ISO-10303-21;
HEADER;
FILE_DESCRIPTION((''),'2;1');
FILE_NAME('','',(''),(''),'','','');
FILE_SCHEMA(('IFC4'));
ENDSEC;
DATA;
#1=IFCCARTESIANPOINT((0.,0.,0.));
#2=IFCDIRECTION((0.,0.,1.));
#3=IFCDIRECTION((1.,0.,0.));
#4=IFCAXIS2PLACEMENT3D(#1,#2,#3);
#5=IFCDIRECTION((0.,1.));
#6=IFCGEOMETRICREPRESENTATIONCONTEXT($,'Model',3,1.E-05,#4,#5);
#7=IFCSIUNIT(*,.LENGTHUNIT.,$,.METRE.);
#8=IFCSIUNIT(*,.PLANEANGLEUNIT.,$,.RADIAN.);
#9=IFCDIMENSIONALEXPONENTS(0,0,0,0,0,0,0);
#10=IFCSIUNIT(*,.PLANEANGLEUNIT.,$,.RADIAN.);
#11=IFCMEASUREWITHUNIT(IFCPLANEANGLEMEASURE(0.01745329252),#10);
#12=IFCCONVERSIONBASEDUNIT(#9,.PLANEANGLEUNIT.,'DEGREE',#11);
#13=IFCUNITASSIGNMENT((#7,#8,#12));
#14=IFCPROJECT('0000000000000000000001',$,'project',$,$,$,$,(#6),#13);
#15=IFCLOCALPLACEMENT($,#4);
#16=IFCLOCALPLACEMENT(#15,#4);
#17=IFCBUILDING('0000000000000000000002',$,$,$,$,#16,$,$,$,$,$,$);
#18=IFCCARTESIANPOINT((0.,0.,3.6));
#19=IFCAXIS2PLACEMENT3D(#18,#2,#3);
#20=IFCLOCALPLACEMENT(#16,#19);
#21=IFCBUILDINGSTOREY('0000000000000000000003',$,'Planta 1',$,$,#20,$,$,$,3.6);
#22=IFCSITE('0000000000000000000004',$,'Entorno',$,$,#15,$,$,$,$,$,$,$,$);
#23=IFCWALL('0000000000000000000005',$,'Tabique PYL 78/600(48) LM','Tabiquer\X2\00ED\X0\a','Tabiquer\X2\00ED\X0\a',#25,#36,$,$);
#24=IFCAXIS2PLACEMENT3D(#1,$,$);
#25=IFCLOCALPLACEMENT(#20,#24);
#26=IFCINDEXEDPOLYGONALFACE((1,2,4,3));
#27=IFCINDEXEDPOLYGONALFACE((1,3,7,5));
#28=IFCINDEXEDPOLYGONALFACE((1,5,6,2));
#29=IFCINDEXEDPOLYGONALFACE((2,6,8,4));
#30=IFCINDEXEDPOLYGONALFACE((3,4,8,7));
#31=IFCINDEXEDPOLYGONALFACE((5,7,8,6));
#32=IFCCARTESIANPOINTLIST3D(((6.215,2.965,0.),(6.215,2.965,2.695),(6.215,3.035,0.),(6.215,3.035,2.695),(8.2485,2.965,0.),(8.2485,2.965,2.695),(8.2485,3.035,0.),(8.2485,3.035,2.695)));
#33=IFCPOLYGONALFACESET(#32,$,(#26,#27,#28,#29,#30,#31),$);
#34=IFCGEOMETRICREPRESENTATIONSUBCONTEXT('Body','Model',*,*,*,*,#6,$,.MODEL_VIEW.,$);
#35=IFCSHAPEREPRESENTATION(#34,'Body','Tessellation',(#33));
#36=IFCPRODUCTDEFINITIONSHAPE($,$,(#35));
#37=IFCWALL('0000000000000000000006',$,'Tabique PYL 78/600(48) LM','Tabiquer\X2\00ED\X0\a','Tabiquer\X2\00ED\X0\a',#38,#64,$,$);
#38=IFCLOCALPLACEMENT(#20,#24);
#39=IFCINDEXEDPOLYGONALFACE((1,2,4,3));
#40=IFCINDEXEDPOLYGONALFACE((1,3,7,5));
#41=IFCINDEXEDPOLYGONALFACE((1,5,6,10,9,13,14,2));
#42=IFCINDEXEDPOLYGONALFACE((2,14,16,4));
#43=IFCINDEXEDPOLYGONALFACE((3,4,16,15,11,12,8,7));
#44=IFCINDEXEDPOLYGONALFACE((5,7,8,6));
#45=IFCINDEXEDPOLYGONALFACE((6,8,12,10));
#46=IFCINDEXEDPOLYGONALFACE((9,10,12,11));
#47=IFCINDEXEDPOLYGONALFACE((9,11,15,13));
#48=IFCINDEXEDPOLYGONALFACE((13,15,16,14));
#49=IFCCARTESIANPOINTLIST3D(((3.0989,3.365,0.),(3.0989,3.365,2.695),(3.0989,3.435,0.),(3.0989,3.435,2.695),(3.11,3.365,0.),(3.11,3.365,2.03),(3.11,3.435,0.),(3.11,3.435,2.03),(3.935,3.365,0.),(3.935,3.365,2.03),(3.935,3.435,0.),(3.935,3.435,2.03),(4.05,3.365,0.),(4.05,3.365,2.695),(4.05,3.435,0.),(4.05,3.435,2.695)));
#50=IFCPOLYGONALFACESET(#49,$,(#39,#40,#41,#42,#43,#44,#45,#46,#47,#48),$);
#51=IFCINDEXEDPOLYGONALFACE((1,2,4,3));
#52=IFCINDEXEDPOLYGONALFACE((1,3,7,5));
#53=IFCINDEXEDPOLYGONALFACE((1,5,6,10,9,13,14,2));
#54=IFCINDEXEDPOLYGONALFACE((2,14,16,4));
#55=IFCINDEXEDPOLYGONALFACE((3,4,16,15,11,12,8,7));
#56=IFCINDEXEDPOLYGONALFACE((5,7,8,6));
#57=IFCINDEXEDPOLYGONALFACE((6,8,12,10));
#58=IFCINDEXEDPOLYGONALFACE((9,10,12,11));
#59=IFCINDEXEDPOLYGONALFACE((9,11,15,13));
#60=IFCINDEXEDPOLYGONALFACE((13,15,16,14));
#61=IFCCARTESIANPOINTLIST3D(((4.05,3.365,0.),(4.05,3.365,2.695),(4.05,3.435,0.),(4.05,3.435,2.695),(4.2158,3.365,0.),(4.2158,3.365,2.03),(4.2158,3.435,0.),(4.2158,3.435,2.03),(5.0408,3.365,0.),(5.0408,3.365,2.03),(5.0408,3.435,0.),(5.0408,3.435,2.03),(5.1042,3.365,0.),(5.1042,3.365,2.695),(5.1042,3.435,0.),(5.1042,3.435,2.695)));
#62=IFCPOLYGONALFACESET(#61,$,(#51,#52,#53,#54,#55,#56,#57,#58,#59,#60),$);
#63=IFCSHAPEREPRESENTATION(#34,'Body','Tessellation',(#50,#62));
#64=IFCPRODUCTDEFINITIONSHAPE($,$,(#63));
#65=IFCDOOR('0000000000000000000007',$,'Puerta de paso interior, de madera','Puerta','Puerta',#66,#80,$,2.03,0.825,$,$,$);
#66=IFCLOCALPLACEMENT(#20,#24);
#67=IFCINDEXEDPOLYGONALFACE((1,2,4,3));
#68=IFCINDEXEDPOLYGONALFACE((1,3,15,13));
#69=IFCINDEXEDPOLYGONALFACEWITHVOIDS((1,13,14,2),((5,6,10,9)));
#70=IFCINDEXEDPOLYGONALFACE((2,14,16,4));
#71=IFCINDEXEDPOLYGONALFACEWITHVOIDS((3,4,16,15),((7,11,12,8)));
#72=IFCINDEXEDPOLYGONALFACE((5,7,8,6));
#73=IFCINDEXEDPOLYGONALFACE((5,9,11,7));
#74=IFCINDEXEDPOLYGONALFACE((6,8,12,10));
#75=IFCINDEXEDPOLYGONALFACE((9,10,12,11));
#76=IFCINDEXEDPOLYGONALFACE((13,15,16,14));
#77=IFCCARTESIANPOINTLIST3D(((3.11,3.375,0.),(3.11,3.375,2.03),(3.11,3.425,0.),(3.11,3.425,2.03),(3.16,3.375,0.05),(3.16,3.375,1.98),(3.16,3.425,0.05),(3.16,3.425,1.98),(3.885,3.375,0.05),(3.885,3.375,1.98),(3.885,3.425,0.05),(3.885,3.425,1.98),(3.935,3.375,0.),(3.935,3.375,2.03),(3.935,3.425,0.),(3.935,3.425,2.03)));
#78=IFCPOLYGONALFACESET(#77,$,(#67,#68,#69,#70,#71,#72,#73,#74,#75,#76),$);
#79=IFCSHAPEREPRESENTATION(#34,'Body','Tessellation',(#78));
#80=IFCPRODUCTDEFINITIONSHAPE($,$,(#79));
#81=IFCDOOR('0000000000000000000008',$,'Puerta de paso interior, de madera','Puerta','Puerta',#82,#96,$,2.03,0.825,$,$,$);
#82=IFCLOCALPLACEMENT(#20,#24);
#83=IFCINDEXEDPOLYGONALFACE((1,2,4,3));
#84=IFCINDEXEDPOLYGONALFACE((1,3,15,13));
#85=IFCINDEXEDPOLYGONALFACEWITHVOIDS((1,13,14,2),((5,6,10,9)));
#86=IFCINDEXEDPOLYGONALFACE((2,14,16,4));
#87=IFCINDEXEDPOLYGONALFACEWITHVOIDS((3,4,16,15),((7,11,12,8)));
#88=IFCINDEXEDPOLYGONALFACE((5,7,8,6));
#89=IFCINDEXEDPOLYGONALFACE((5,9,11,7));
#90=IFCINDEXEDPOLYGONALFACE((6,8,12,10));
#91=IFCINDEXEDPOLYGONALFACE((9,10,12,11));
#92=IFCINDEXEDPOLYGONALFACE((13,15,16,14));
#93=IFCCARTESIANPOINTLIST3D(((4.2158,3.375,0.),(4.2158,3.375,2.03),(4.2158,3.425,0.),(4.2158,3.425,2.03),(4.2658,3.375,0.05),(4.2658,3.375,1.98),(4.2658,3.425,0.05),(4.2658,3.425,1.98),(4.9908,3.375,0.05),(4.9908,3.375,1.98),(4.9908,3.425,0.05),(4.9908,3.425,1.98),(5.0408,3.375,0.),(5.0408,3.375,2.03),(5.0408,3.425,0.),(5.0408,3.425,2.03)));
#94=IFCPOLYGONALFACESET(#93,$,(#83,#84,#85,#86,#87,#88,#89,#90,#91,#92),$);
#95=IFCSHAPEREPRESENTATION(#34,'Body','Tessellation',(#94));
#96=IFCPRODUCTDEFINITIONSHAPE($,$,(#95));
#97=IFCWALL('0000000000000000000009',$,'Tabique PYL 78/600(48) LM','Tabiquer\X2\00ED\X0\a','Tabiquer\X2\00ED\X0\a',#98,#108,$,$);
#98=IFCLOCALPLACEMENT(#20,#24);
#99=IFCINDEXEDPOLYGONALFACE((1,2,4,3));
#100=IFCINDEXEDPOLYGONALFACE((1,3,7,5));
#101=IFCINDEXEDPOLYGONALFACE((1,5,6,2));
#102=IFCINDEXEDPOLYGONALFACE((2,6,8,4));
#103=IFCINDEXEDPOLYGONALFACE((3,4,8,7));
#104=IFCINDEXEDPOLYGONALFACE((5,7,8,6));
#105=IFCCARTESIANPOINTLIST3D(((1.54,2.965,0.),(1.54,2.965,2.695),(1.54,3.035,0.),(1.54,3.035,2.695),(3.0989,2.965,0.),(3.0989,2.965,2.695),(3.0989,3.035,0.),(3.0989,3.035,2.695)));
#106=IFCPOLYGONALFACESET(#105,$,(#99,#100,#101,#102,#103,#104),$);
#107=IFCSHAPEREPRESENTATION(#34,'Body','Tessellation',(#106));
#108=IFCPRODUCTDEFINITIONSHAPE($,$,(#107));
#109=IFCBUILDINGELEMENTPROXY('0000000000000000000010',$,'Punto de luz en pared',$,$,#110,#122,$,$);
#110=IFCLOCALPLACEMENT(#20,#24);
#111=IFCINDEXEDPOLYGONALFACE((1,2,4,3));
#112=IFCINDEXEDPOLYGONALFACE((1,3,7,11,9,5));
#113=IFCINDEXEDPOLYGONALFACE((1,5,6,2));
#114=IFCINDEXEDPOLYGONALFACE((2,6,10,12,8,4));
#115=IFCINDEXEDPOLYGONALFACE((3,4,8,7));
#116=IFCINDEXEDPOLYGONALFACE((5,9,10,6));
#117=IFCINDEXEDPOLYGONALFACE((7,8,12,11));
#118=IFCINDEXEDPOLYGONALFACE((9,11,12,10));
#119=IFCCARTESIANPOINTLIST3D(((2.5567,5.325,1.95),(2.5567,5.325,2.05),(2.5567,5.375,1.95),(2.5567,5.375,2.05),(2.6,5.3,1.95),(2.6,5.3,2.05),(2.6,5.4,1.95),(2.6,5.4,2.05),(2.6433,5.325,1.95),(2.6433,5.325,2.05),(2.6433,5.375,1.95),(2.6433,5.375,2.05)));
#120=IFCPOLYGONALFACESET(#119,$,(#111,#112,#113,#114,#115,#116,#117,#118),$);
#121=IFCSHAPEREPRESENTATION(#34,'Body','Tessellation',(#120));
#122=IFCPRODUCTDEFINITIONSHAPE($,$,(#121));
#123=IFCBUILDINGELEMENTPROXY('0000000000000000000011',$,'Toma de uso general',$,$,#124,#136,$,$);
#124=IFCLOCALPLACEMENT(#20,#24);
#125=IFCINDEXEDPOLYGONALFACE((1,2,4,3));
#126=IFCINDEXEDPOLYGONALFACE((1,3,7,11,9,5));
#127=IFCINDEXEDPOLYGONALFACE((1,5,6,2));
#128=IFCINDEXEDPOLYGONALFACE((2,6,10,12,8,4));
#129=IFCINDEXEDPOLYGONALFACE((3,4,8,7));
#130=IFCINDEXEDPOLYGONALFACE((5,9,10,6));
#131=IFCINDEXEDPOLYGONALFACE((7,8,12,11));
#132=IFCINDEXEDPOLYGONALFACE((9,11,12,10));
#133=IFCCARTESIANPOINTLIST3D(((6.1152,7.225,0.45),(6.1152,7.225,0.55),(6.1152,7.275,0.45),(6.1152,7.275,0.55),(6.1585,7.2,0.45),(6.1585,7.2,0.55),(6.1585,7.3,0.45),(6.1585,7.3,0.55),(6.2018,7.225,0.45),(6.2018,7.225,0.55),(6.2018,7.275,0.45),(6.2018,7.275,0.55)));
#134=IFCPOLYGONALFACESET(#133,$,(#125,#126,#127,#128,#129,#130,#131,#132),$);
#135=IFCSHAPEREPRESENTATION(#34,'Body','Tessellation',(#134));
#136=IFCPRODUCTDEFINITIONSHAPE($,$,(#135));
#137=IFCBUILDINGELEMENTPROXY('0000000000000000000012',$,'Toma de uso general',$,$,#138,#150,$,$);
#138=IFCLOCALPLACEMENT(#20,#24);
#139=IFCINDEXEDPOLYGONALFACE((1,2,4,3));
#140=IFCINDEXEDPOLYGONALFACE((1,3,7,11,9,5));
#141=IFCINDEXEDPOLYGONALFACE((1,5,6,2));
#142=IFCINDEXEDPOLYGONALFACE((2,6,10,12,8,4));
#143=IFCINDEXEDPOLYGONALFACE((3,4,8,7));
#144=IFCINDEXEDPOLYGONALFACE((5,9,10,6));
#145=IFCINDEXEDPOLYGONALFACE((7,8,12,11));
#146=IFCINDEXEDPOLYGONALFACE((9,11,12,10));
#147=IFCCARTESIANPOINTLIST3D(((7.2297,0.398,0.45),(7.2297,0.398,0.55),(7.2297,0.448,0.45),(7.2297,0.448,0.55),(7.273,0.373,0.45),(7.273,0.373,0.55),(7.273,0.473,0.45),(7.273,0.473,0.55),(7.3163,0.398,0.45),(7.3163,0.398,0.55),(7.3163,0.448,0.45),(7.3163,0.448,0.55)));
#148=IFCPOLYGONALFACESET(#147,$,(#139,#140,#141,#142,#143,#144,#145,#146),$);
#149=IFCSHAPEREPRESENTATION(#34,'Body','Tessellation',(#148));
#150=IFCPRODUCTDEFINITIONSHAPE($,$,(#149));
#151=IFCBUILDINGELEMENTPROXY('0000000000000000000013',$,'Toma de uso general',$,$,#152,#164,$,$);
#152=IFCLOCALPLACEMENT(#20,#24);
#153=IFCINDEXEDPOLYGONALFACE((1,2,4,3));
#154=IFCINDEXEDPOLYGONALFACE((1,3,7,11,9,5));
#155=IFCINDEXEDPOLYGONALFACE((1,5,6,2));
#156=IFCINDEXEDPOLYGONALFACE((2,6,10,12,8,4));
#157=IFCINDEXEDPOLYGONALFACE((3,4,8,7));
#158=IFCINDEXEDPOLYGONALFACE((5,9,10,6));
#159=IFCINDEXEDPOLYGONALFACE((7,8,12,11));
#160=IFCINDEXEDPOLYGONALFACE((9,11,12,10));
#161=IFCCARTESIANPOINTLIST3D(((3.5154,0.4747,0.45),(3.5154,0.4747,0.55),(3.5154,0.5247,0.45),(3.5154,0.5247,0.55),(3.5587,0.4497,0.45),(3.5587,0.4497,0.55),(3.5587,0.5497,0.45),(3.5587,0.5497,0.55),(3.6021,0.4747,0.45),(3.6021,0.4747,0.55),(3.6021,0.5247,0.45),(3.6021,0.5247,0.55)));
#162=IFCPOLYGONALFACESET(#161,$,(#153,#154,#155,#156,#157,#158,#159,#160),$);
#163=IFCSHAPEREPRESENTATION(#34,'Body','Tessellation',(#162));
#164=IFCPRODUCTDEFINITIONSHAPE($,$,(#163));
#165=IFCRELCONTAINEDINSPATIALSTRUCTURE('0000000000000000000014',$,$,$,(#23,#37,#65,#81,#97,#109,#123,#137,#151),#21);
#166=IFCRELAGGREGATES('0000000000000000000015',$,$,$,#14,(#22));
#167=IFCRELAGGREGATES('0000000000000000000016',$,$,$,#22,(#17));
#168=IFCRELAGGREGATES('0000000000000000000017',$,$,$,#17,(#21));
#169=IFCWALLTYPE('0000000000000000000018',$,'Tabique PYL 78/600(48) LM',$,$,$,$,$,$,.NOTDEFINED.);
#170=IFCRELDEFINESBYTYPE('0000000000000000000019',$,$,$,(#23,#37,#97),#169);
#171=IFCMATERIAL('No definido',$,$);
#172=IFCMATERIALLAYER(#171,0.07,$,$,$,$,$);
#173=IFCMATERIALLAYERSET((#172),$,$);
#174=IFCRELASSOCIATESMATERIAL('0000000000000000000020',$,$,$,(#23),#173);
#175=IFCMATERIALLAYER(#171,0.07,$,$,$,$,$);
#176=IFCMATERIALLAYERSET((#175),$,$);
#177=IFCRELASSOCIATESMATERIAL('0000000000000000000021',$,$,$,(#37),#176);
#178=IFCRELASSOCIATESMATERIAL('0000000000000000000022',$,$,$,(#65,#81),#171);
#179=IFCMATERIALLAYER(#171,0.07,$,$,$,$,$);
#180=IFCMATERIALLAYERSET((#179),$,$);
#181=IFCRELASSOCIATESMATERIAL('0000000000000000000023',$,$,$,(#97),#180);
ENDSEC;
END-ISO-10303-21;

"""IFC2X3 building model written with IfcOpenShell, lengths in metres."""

from ifc_helpers import new_model, entity, si_unit, converted_unit, direction, frame, origin_with_axes, origin_2d_with_axis, place, context, subcontext, project, spatial, polyline, rectangle, hollow_rectangle, outline, extrude, shape, source, transform, mapped, material, layer, layer_set, layer_usage, type_object, element, fill, save


model = new_model("IFC2X3")

# Units and contexts
model_context = context("Model", 3, precision=1e-05, world=origin_with_axes(), true_north=direction((0.0, 1.0)))
body_context = subcontext(model_context, "Body", "Model", "MODEL_VIEW")
footprint_context = subcontext(model_context, "FootPrint", "Model", "MODEL_VIEW")
ifc_project = project(units=[si_unit("LENGTHUNIT", "METRE"), si_unit("PLANEANGLEUNIT", "RADIAN"), converted_unit("PLANEANGLEUNIT", "DEGREE", entity("IfcPlaneAngleMeasure", 0.01745329252), si_unit("PLANEANGLEUNIT", "RADIAN"), dimensions=[0, 0, 0, 0, 0, 0, 0])], contexts=[model_context])

# Site, building, storey
site_placement = place(None, origin_with_axes())
site = spatial("IfcSite", under=ifc_project, at=site_placement, Name="Entorno")
building_placement = place(site_placement, origin_with_axes())
building = spatial("IfcBuilding", under=site, at=building_placement)
storey_placement = place(building_placement, frame((0.0, 0.0, 3.6), z_axis=(0.0, 0.0, 1.0), x_axis=(1.0, 0.0, 0.0)))
storey = spatial("IfcBuildingStorey", under=building, at=storey_placement, Name="Planta 1", Elevation=3.6)

# Shared definitions
ifc_material = material(Name="No definido")

# Shared definitions
wall_type = type_object("IfcWallType", Name="Tabique PYL 78/600(48) LM")

# Wall
ifc_layer_1 = layer(ifc_material, 0.07)
ifc_layer_set_1 = layer_set([ifc_layer_1])
ifc_layer_usage_1 = layer_usage(ifc_layer_set_1, "AXIS2", "POSITIVE", -0.035)
wall_1_placement = place(storey_placement, frame((6.25, 3.0, 0.0), z_axis=(0.0, 0.0, 1.0), x_axis=(1.0, 0.0, 0.0)))
element("IfcWall", 1, at=wall_1_placement, inside=storey, type_object=wall_type, material=ifc_layer_usage_1, Name="Tabique PYL 78/600(48) LM", Description="Tabiquería", ObjectType="Tabiquería", context=body_context, shape_type="SolidModel", body=[
    extrude(outline(polyline([(-1.0168, -1.3475), (1.0168, -1.3475), (1.0168, 1.3475), (-1.0168, 1.3475), (-1.0168, -1.3475)])), frame((0.9818, 0.035, 1.3475), z_axis=(0.0, -1.0, 0.0), x_axis=(1.0, 0.0, 0.0)), (0.0, 0.0, 1.0), 0.07),
])

# Wall, openings, doors
ifc_layer_2 = layer(ifc_material, 0.07)
ifc_layer_set_2 = layer_set([ifc_layer_2])
ifc_layer_usage_2 = layer_usage(ifc_layer_set_2, "AXIS2", "POSITIVE", -0.035)
wall_2_placement = place(storey_placement, frame((3.0639, 3.4, 0.0), z_axis=(0.0, 0.0, 1.0), x_axis=(1.0, 0.0, 0.0)))
wall_2 = element("IfcWall", 2, at=wall_2_placement, inside=storey, type_object=wall_type, material=ifc_layer_usage_2, Name="Tabique PYL 78/600(48) LM", Description="Tabiquería", ObjectType="Tabiquería", context=body_context, shape_type="SolidModel", body=[
    extrude(outline(polyline([(-0.4755, -1.3475), (0.4755, -1.3475), (0.4755, 1.3475), (-0.4755, 1.3475), (-0.4755, -1.3475)])), frame((0.5106, 0.035, 1.3475), z_axis=(0.0, -1.0, 0.0), x_axis=(1.0, 0.0, 0.0)), (0.0, 0.0, 1.0), 0.07),
    extrude(outline(polyline([(-0.5271, -1.3475), (0.5271, -1.3475), (0.5271, 1.3475), (-0.5271, 1.3475), (-0.5271, -1.3475)])), frame((1.5132, 0.035, 1.3475), z_axis=(0.0, -1.0, 0.0), x_axis=(1.0, 0.0, 0.0)), (0.0, 0.0, 1.0), 0.07),
])
opening_1_placement = place(wall_2_placement, frame((0.4586, 0.0, 1.015), z_axis=(0.0, 0.0, 1.0), x_axis=(1.0, 0.0, 0.0)))
cartesian_point_1 = entity("IfcCartesianPoint", [-0.4125, -0.035])
opening_1 = element("IfcOpeningElement", 3, at=opening_1_placement, cuts=wall_2, ObjectType="No definido", shapes=[
    shape(body_context, "Body", "SweptSolid", [extrude(rectangle(XDim=2.03, YDim=0.825, at=origin_2d_with_axis()), frame((0.0, -0.035, 0.0), z_axis=(0.0, 1.0, 0.0), x_axis=(0.0, 0.0, 1.0)), (0.0, 0.0, 1.0), 0.07)]),
    shape(footprint_context, "FootPrint", "GeometricCurveSet", [entity("IfcGeometricCurveSet", [entity("IfcPolyline", [cartesian_point_1, entity("IfcCartesianPoint", [0.4125, -0.035]), entity("IfcCartesianPoint", [0.4125, 0.035]), entity("IfcCartesianPoint", [-0.4125, 0.035]), cartesian_point_1])])]),
])
opening_2_placement = place(wall_2_placement, frame((1.5644, 0.0, 1.015), z_axis=(0.0, 0.0, 1.0), x_axis=(1.0, 0.0, 0.0)))
cartesian_point_2 = entity("IfcCartesianPoint", [-0.4125, -0.035])
opening_2 = element("IfcOpeningElement", 4, at=opening_2_placement, cuts=wall_2, ObjectType="No definido", shapes=[
    shape(body_context, "Body", "SweptSolid", [extrude(rectangle(XDim=2.03, YDim=0.825, at=origin_2d_with_axis()), frame((0.0, -0.035, 0.0), z_axis=(0.0, 1.0, 0.0), x_axis=(0.0, 0.0, 1.0)), (0.0, 0.0, 1.0), 0.07)]),
    shape(footprint_context, "FootPrint", "GeometricCurveSet", [entity("IfcGeometricCurveSet", [entity("IfcPolyline", [cartesian_point_2, entity("IfcCartesianPoint", [0.4125, -0.035]), entity("IfcCartesianPoint", [0.4125, 0.035]), entity("IfcCartesianPoint", [-0.4125, 0.035]), cartesian_point_2])])]),
])
door_1_placement = place(opening_1_placement, origin_with_axes())
door_1 = element("IfcDoor", 5, at=door_1_placement, inside=storey, material=ifc_material, Name="Puerta de paso interior, de madera", Description="Puerta", ObjectType="Puerta", OverallHeight=2.03, OverallWidth=0.825, context=body_context, shape_type="SweptSolid", body=[
    extrude(hollow_rectangle(XDim=0.825, YDim=2.03, WallThickness=0.05, InnerFilletRadius=0.0, OuterFilletRadius=0.0, at=origin_2d_with_axis()), frame((0.0, 0.025, 0.0), z_axis=(0.0, -1.0, 0.0), x_axis=(1.0, 0.0, 0.0)), (0.0, 0.0, 1.0), 0.05),
])
fill(opening_1, door_1)
door_2_placement = place(opening_2_placement, origin_with_axes())
door_2 = element("IfcDoor", 6, at=door_2_placement, inside=storey, material=ifc_material, Name="Puerta de paso interior, de madera", Description="Puerta", ObjectType="Puerta", OverallHeight=2.03, OverallWidth=0.825, context=body_context, shape_type="SweptSolid", body=[
    extrude(hollow_rectangle(XDim=0.825, YDim=2.03, WallThickness=0.05, InnerFilletRadius=0.0, OuterFilletRadius=0.0, at=origin_2d_with_axis()), frame((0.0, 0.025, 0.0), z_axis=(0.0, -1.0, 0.0), x_axis=(1.0, 0.0, 0.0)), (0.0, 0.0, 1.0), 0.05),
])
fill(opening_2, door_2)

# Wall
ifc_layer_3 = layer(ifc_material, 0.07)
ifc_layer_set_3 = layer_set([ifc_layer_3])
ifc_layer_usage_3 = layer_usage(ifc_layer_set_3, "AXIS2", "POSITIVE", -0.035)
wall_3_placement = place(storey_placement, frame((1.575, 3.0, 0.0), z_axis=(0.0, 0.0, 1.0), x_axis=(1.0, 0.0, 0.0)))
element("IfcWall", 7, at=wall_3_placement, inside=storey, type_object=wall_type, material=ifc_layer_usage_3, Name="Tabique PYL 78/600(48) LM", Description="Tabiquería", ObjectType="Tabiquería", context=body_context, shape_type="SolidModel", body=[
    extrude(outline(polyline([(-0.7794, -1.3475), (0.7794, -1.3475), (0.7794, 1.3475), (-0.7794, 1.3475), (-0.7794, -1.3475)])), frame((0.7445, 0.035, 1.3475), z_axis=(0.0, -1.0, 0.0), x_axis=(1.0, 0.0, 0.0)), (0.0, 0.0, 1.0), 0.07),
])

# Building element proxies
shared_shape_1 = source(origin_with_axes(), body_context, "Body", "SolidModel", [
    extrude(outline(polyline([(0.05, 0.0), (0.025, 0.0433), (-0.025, 0.0433), (-0.05, 0.0), (-0.025, -0.0433), (0.025, -0.0433), (0.05, 0.0)])), frame((0.0, 0.0, -0.05), z_axis=(0.0, 0.0, 1.0), x_axis=(1.0, 0.0, 0.0)), (0.0, 0.0, 1.0), 0.1),
])
proxy_1_placement = place(storey_placement, frame((0.0, 0.0, -3.6), z_axis=(0.0, 0.0, 1.0), x_axis=(1.0, 0.0, 0.0)))
element("IfcBuildingElementProxy", 8, at=proxy_1_placement, inside=storey, Name="Punto de luz en pared", context=body_context, shape_type="Brep", body=[
    mapped(shared_shape_1, transform((2.6, 5.35, 5.6), x_axis=(0.0, -1.0, 0.0), y_axis=(1.0, 0.0, 0.0), z_axis=(0.0, 0.0, 1.0))),
])
shared_shape_2 = source(origin_with_axes(), body_context, "Body", "SolidModel", [
    extrude(outline(polyline([(0.05, 0.0), (0.025, 0.0433), (-0.025, 0.0433), (-0.05, 0.0), (-0.025, -0.0433), (0.025, -0.0433), (0.05, 0.0)])), frame((0.0, 0.0, -0.05), z_axis=(0.0, 0.0, 1.0), x_axis=(1.0, 0.0, 0.0)), (0.0, 0.0, 1.0), 0.1),
])
proxy_2_placement = place(storey_placement, frame((0.0, 0.0, -3.6), z_axis=(0.0, 0.0, 1.0), x_axis=(1.0, 0.0, 0.0)))
element("IfcBuildingElementProxy", 9, at=proxy_2_placement, inside=storey, Name="Toma de uso general", context=body_context, shape_type="Brep", body=[
    mapped(shared_shape_2, transform((6.1585, 7.25, 4.1), x_axis=(0.0, 1.0, 0.0), y_axis=(-1.0, 0.0, 0.0), z_axis=(0.0, 0.0, 1.0))),
])
proxy_3_placement = place(storey_placement, frame((0.0, 0.0, -3.6), z_axis=(0.0, 0.0, 1.0), x_axis=(1.0, 0.0, 0.0)))
element("IfcBuildingElementProxy", 10, at=proxy_3_placement, inside=storey, Name="Toma de uso general", context=body_context, shape_type="Brep", body=[
    mapped(shared_shape_2, transform((7.273, 0.423, 4.1), x_axis=(0.0, 1.0, 0.0), y_axis=(-1.0, 0.0, 0.0), z_axis=(0.0, 0.0, 1.0))),
])
proxy_4_placement = place(storey_placement, frame((0.0, 0.0, -3.6), z_axis=(0.0, 0.0, 1.0), x_axis=(1.0, 0.0, 0.0)))
element("IfcBuildingElementProxy", 11, at=proxy_4_placement, inside=storey, Name="Toma de uso general", context=body_context, shape_type="Brep", body=[
    mapped(shared_shape_2, transform((3.5587, 0.4997, 4.1), x_axis=(0.0, 1.0, 0.0), y_axis=(-1.0, 0.0, 0.0), z_axis=(0.0, 0.0, 1.0))),
])

save(model, "model.ifc")
